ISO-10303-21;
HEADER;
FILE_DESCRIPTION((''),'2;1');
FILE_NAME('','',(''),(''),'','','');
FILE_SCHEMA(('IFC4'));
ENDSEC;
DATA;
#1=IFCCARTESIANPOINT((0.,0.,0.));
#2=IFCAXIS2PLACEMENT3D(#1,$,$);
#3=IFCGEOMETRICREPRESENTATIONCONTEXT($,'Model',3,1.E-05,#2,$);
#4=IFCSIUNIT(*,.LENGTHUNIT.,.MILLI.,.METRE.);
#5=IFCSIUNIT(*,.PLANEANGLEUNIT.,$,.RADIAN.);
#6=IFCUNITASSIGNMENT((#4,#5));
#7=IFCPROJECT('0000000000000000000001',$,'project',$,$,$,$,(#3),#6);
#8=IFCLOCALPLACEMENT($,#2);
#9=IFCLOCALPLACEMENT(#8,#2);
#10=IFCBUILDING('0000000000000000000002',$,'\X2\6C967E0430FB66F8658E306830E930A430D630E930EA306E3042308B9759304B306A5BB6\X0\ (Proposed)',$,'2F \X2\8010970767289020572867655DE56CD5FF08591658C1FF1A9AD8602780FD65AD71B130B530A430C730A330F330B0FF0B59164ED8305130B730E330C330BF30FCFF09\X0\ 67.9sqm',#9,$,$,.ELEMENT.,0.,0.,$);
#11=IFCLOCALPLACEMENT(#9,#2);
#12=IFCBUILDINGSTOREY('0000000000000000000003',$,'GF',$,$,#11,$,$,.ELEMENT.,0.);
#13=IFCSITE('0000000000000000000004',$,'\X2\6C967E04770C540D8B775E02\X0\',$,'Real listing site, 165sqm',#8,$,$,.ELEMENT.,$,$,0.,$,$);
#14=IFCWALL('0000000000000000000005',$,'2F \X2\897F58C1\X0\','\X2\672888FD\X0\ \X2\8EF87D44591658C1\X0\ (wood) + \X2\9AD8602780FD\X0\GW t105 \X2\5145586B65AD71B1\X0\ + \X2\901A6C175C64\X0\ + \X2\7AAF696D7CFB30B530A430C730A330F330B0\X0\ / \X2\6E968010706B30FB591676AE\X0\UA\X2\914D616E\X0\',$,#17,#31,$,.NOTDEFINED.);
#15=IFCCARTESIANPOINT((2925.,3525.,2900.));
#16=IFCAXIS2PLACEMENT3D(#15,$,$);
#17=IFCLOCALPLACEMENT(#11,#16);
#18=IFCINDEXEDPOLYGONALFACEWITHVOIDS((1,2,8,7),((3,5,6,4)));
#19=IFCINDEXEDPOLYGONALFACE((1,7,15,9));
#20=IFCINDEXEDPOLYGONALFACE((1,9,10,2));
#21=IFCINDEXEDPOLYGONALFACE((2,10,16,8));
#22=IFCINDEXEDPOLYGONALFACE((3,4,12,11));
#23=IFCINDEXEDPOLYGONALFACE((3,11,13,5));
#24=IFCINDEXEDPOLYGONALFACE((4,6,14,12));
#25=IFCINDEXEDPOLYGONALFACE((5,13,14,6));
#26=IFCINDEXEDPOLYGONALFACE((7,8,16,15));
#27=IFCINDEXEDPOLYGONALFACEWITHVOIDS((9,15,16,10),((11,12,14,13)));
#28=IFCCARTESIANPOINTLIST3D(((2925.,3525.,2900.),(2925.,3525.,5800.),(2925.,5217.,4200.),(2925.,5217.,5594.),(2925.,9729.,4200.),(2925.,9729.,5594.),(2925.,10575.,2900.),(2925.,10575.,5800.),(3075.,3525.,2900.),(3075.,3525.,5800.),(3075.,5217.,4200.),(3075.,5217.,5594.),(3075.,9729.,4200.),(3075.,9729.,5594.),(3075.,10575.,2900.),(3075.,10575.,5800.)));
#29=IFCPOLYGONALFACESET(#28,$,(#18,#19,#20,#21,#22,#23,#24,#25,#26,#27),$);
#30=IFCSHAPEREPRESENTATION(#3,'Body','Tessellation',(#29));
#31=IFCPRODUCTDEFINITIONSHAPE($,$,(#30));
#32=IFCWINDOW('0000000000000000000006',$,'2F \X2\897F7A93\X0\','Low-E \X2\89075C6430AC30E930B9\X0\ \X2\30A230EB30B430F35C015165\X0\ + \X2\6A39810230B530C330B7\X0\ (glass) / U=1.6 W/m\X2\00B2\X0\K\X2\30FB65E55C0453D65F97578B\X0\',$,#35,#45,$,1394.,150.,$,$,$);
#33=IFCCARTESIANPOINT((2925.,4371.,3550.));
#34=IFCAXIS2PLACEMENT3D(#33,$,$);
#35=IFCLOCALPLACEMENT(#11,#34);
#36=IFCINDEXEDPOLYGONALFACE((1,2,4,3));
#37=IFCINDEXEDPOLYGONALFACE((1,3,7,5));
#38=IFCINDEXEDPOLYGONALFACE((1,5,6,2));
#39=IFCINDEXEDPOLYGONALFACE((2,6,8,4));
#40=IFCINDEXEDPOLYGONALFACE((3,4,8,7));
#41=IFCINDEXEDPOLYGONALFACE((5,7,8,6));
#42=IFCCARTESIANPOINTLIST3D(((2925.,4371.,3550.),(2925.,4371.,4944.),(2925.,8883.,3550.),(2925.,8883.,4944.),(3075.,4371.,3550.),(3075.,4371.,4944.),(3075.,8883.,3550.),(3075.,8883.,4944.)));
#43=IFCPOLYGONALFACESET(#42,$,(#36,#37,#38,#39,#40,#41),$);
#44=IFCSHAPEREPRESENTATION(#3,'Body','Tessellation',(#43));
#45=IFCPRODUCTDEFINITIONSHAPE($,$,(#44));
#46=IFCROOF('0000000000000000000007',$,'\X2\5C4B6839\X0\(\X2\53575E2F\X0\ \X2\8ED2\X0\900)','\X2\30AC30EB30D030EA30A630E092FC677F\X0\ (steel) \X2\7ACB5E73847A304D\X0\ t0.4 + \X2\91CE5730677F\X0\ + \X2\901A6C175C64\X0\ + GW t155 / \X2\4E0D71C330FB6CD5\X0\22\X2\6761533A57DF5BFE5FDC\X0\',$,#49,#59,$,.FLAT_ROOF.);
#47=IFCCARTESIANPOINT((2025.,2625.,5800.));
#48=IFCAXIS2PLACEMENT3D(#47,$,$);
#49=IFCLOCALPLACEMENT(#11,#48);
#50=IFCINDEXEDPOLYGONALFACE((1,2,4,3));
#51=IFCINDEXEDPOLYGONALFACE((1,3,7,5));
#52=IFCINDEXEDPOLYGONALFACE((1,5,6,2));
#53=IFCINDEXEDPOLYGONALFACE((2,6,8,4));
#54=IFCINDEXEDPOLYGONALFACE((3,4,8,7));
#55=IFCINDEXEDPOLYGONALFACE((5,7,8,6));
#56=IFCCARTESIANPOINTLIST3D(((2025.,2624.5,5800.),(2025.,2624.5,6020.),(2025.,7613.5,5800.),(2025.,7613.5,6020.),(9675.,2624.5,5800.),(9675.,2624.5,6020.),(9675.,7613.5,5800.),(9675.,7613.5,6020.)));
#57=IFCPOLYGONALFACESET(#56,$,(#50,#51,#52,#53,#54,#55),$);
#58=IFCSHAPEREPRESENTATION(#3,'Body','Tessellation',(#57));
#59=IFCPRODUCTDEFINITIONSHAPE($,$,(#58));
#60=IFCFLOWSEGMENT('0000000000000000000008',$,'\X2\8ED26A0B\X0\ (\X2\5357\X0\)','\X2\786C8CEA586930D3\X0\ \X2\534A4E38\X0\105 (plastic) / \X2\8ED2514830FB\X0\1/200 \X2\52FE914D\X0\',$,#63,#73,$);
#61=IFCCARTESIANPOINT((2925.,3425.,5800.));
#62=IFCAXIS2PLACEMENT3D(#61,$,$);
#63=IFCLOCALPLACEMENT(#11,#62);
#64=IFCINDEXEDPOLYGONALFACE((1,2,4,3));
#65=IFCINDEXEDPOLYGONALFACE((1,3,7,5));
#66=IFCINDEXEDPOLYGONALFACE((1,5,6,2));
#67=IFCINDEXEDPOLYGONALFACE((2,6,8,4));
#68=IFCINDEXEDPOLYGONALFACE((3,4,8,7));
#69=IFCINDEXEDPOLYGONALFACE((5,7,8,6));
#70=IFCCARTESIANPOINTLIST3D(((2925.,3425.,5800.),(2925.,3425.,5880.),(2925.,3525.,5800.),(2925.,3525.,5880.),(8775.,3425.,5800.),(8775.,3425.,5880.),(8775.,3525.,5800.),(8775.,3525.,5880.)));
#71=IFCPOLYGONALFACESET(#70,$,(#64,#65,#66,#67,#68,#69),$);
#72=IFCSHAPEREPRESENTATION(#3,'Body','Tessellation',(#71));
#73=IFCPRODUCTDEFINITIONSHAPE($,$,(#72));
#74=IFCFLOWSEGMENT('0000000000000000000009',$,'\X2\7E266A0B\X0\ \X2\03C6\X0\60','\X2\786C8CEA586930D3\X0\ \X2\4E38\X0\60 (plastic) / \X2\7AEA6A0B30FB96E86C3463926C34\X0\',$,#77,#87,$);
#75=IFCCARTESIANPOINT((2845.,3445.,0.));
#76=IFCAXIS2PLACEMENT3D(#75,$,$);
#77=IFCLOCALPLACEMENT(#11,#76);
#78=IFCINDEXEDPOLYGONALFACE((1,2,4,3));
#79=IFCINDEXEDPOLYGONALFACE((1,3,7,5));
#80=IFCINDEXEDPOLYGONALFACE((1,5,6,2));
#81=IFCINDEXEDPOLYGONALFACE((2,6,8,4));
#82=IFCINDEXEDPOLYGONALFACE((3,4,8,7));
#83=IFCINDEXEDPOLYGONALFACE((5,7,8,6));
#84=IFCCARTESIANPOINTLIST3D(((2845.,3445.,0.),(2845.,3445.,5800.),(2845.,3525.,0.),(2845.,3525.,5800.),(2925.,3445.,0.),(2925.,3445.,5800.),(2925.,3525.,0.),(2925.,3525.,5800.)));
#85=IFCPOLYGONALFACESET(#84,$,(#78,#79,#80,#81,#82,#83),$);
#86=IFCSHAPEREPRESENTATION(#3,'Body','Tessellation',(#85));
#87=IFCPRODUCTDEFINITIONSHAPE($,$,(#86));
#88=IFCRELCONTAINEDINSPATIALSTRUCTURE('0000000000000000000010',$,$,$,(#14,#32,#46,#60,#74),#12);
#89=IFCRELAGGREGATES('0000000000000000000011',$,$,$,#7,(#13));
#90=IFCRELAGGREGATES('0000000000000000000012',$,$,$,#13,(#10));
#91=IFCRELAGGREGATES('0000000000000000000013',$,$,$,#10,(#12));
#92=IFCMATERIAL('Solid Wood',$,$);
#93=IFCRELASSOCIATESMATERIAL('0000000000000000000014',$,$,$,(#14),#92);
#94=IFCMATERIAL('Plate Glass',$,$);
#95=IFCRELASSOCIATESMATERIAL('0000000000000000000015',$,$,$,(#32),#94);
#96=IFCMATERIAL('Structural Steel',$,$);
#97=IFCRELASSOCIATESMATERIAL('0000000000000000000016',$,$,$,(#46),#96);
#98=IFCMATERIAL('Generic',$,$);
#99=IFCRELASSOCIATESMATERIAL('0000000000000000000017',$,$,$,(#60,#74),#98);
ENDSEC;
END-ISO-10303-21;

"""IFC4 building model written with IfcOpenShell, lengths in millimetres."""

from ifc_helpers import new_model, si_unit, frame, frame_2d, origin, place, context, project, spatial, rectangle, extrude, material, element, fill, save


model = new_model("IFC4")

# Units and contexts
model_context = context("Model", 3, precision=1e-05, world=origin())
ifc_project = project(units=[si_unit("LENGTHUNIT", "METRE", prefix="MILLI"), si_unit("PLANEANGLEUNIT", "RADIAN")], contexts=[model_context])

# Site, building, storey
site_placement = place(None, origin())
site = spatial("IfcSite", under=ifc_project, at=site_placement, Name="沖縄県名護市", ObjectType="Real listing site, 165sqm", CompositionType="ELEMENT", RefElevation=0.0)
building_placement = place(site_placement, origin())
building = spatial("IfcBuilding", under=site, at=building_placement, Name="沖縄・書斎とライブラリのある静かな家 (Proposed)", ObjectType="2F 耐震木造在来工法（外壁：高性能断熱サイディング＋外付けシャッター） 67.9sqm", CompositionType="ELEMENT", ElevationOfRefHeight=0.0, ElevationOfTerrain=0.0)
storey_placement = place(building_placement, origin())
storey = spatial("IfcBuildingStorey", under=building, at=storey_placement, Name="GF", CompositionType="ELEMENT", Elevation=0.0)

# Shared definitions
ifc_material_1 = material(Name="Solid Wood")

# Shared definitions
ifc_material_2 = material(Name="Plate Glass")

# Wall, opening, window
wall_1_placement = place(storey_placement, frame((2925.0, 3525.0, 2900.0)))
wall_1 = element("IfcWall", 1, at=wall_1_placement, inside=storey, material=ifc_material_1, Name="2F 西壁", Description="木製 軸組外壁 (wood) + 高性能GW t105 充填断熱 + 通気層 + 窯業系サイディング / 準耐火・外皮UA配慮", PredefinedType="NOTDEFINED", context=model_context, shape_type="SweptSolid", body=[
    extrude(rectangle(XDim=150.0, YDim=7050.0, at=frame_2d((75.0, 3525.0))), frame((2925.0, 3525.0, 2900.0)), (0.0, 0.0, 1.0), 2900.0),
])
opening_1_placement = place(storey_placement, frame((2925.0, 4371.0, 3550.0)))
opening_1 = element("IfcOpeningElement", 2, at=opening_1_placement, cuts=wall_1, PredefinedType="NOTDEFINED", context=model_context, shape_type="SweptSolid", body=[
    extrude(rectangle(XDim=150.0, YDim=4512.0, at=frame_2d((75.0, 2256.0))), frame((2925.0, 4371.0, 3550.0)), (0.0, 0.0, 1.0), 1394.0),
])
window_1_placement = place(storey_placement, frame((2925.0, 4371.0, 3550.0)))
window_1 = element("IfcWindow", 3, at=window_1_placement, inside=storey, material=ifc_material_2, Name="2F 西窓", Description="Low-E 複層ガラス アルゴン封入 + 樹脂サッシ (glass) / U=1.6 W/m²K・日射取得型", OverallHeight=1394.0, OverallWidth=150.0, context=model_context, shape_type="SweptSolid", body=[
    extrude(rectangle(XDim=150.0, YDim=4512.0, at=frame_2d((75.0, 2256.0))), frame((2925.0, 4371.0, 3550.0)), (0.0, 0.0, 1.0), 1394.0),
])
fill(opening_1, window_1)

# Roof
ifc_material_3 = material(Name="Structural Steel")
for number, where, name in (
    (4, (2025.0, 2625.0, 5800.0), "屋根(南帯 軒900)"),
):
    element("IfcRoof", number, at=place(storey_placement, frame(where)), inside=storey, material=ifc_material_3, Name=name, Description="ガルバリウム鋼板 (steel) 立平葺き t0.4 + 野地板 + 通気層 + GW t155 / 不燃・法22条区域対応", PredefinedType="FLAT_ROOF", context=model_context, shape_type="SweptSolid", body=[
        extrude(rectangle(XDim=7650.0, YDim=4989.0, at=frame_2d((3825.0, 2494.0))), frame((2025.0, 2625.0, 5800.0)), (0.0, 0.0, 1.0), 220.0),
    ])

# Flow segments
ifc_material_4 = material(Name="Generic")
flow_segment_1_placement = place(storey_placement, frame((2925.0, 3425.0, 5800.0)))
element("IfcFlowSegment", 5, at=flow_segment_1_placement, inside=storey, material=ifc_material_4, Name="軒樋 (南)", Description="硬質塩ビ 半丸105 (plastic) / 軒先・1/200 勾配", context=model_context, shape_type="SweptSolid", body=[
    extrude(rectangle(XDim=5850.0, YDim=100.0, at=frame_2d((2925.0, 50.0))), frame((2925.0, 3425.0, 5800.0)), (0.0, 0.0, 1.0), 80.0),
])
flow_segment_2_placement = place(storey_placement, frame((2845.0, 3445.0, 0.0)))
element("IfcFlowSegment", 6, at=flow_segment_2_placement, inside=storey, material=ifc_material_4, Name="縦樋 φ60", Description="硬質塩ビ 丸60 (plastic) / 竪樋・雨水排水", context=model_context, shape_type="SweptSolid", body=[
    extrude(rectangle(XDim=80.0, YDim=80.0, at=frame_2d((40.0, 40.0))), frame((2845.0, 3445.0, 0.0)), (0.0, 0.0, 1.0), 5800.0),
])

save(model, "model.ifc")
